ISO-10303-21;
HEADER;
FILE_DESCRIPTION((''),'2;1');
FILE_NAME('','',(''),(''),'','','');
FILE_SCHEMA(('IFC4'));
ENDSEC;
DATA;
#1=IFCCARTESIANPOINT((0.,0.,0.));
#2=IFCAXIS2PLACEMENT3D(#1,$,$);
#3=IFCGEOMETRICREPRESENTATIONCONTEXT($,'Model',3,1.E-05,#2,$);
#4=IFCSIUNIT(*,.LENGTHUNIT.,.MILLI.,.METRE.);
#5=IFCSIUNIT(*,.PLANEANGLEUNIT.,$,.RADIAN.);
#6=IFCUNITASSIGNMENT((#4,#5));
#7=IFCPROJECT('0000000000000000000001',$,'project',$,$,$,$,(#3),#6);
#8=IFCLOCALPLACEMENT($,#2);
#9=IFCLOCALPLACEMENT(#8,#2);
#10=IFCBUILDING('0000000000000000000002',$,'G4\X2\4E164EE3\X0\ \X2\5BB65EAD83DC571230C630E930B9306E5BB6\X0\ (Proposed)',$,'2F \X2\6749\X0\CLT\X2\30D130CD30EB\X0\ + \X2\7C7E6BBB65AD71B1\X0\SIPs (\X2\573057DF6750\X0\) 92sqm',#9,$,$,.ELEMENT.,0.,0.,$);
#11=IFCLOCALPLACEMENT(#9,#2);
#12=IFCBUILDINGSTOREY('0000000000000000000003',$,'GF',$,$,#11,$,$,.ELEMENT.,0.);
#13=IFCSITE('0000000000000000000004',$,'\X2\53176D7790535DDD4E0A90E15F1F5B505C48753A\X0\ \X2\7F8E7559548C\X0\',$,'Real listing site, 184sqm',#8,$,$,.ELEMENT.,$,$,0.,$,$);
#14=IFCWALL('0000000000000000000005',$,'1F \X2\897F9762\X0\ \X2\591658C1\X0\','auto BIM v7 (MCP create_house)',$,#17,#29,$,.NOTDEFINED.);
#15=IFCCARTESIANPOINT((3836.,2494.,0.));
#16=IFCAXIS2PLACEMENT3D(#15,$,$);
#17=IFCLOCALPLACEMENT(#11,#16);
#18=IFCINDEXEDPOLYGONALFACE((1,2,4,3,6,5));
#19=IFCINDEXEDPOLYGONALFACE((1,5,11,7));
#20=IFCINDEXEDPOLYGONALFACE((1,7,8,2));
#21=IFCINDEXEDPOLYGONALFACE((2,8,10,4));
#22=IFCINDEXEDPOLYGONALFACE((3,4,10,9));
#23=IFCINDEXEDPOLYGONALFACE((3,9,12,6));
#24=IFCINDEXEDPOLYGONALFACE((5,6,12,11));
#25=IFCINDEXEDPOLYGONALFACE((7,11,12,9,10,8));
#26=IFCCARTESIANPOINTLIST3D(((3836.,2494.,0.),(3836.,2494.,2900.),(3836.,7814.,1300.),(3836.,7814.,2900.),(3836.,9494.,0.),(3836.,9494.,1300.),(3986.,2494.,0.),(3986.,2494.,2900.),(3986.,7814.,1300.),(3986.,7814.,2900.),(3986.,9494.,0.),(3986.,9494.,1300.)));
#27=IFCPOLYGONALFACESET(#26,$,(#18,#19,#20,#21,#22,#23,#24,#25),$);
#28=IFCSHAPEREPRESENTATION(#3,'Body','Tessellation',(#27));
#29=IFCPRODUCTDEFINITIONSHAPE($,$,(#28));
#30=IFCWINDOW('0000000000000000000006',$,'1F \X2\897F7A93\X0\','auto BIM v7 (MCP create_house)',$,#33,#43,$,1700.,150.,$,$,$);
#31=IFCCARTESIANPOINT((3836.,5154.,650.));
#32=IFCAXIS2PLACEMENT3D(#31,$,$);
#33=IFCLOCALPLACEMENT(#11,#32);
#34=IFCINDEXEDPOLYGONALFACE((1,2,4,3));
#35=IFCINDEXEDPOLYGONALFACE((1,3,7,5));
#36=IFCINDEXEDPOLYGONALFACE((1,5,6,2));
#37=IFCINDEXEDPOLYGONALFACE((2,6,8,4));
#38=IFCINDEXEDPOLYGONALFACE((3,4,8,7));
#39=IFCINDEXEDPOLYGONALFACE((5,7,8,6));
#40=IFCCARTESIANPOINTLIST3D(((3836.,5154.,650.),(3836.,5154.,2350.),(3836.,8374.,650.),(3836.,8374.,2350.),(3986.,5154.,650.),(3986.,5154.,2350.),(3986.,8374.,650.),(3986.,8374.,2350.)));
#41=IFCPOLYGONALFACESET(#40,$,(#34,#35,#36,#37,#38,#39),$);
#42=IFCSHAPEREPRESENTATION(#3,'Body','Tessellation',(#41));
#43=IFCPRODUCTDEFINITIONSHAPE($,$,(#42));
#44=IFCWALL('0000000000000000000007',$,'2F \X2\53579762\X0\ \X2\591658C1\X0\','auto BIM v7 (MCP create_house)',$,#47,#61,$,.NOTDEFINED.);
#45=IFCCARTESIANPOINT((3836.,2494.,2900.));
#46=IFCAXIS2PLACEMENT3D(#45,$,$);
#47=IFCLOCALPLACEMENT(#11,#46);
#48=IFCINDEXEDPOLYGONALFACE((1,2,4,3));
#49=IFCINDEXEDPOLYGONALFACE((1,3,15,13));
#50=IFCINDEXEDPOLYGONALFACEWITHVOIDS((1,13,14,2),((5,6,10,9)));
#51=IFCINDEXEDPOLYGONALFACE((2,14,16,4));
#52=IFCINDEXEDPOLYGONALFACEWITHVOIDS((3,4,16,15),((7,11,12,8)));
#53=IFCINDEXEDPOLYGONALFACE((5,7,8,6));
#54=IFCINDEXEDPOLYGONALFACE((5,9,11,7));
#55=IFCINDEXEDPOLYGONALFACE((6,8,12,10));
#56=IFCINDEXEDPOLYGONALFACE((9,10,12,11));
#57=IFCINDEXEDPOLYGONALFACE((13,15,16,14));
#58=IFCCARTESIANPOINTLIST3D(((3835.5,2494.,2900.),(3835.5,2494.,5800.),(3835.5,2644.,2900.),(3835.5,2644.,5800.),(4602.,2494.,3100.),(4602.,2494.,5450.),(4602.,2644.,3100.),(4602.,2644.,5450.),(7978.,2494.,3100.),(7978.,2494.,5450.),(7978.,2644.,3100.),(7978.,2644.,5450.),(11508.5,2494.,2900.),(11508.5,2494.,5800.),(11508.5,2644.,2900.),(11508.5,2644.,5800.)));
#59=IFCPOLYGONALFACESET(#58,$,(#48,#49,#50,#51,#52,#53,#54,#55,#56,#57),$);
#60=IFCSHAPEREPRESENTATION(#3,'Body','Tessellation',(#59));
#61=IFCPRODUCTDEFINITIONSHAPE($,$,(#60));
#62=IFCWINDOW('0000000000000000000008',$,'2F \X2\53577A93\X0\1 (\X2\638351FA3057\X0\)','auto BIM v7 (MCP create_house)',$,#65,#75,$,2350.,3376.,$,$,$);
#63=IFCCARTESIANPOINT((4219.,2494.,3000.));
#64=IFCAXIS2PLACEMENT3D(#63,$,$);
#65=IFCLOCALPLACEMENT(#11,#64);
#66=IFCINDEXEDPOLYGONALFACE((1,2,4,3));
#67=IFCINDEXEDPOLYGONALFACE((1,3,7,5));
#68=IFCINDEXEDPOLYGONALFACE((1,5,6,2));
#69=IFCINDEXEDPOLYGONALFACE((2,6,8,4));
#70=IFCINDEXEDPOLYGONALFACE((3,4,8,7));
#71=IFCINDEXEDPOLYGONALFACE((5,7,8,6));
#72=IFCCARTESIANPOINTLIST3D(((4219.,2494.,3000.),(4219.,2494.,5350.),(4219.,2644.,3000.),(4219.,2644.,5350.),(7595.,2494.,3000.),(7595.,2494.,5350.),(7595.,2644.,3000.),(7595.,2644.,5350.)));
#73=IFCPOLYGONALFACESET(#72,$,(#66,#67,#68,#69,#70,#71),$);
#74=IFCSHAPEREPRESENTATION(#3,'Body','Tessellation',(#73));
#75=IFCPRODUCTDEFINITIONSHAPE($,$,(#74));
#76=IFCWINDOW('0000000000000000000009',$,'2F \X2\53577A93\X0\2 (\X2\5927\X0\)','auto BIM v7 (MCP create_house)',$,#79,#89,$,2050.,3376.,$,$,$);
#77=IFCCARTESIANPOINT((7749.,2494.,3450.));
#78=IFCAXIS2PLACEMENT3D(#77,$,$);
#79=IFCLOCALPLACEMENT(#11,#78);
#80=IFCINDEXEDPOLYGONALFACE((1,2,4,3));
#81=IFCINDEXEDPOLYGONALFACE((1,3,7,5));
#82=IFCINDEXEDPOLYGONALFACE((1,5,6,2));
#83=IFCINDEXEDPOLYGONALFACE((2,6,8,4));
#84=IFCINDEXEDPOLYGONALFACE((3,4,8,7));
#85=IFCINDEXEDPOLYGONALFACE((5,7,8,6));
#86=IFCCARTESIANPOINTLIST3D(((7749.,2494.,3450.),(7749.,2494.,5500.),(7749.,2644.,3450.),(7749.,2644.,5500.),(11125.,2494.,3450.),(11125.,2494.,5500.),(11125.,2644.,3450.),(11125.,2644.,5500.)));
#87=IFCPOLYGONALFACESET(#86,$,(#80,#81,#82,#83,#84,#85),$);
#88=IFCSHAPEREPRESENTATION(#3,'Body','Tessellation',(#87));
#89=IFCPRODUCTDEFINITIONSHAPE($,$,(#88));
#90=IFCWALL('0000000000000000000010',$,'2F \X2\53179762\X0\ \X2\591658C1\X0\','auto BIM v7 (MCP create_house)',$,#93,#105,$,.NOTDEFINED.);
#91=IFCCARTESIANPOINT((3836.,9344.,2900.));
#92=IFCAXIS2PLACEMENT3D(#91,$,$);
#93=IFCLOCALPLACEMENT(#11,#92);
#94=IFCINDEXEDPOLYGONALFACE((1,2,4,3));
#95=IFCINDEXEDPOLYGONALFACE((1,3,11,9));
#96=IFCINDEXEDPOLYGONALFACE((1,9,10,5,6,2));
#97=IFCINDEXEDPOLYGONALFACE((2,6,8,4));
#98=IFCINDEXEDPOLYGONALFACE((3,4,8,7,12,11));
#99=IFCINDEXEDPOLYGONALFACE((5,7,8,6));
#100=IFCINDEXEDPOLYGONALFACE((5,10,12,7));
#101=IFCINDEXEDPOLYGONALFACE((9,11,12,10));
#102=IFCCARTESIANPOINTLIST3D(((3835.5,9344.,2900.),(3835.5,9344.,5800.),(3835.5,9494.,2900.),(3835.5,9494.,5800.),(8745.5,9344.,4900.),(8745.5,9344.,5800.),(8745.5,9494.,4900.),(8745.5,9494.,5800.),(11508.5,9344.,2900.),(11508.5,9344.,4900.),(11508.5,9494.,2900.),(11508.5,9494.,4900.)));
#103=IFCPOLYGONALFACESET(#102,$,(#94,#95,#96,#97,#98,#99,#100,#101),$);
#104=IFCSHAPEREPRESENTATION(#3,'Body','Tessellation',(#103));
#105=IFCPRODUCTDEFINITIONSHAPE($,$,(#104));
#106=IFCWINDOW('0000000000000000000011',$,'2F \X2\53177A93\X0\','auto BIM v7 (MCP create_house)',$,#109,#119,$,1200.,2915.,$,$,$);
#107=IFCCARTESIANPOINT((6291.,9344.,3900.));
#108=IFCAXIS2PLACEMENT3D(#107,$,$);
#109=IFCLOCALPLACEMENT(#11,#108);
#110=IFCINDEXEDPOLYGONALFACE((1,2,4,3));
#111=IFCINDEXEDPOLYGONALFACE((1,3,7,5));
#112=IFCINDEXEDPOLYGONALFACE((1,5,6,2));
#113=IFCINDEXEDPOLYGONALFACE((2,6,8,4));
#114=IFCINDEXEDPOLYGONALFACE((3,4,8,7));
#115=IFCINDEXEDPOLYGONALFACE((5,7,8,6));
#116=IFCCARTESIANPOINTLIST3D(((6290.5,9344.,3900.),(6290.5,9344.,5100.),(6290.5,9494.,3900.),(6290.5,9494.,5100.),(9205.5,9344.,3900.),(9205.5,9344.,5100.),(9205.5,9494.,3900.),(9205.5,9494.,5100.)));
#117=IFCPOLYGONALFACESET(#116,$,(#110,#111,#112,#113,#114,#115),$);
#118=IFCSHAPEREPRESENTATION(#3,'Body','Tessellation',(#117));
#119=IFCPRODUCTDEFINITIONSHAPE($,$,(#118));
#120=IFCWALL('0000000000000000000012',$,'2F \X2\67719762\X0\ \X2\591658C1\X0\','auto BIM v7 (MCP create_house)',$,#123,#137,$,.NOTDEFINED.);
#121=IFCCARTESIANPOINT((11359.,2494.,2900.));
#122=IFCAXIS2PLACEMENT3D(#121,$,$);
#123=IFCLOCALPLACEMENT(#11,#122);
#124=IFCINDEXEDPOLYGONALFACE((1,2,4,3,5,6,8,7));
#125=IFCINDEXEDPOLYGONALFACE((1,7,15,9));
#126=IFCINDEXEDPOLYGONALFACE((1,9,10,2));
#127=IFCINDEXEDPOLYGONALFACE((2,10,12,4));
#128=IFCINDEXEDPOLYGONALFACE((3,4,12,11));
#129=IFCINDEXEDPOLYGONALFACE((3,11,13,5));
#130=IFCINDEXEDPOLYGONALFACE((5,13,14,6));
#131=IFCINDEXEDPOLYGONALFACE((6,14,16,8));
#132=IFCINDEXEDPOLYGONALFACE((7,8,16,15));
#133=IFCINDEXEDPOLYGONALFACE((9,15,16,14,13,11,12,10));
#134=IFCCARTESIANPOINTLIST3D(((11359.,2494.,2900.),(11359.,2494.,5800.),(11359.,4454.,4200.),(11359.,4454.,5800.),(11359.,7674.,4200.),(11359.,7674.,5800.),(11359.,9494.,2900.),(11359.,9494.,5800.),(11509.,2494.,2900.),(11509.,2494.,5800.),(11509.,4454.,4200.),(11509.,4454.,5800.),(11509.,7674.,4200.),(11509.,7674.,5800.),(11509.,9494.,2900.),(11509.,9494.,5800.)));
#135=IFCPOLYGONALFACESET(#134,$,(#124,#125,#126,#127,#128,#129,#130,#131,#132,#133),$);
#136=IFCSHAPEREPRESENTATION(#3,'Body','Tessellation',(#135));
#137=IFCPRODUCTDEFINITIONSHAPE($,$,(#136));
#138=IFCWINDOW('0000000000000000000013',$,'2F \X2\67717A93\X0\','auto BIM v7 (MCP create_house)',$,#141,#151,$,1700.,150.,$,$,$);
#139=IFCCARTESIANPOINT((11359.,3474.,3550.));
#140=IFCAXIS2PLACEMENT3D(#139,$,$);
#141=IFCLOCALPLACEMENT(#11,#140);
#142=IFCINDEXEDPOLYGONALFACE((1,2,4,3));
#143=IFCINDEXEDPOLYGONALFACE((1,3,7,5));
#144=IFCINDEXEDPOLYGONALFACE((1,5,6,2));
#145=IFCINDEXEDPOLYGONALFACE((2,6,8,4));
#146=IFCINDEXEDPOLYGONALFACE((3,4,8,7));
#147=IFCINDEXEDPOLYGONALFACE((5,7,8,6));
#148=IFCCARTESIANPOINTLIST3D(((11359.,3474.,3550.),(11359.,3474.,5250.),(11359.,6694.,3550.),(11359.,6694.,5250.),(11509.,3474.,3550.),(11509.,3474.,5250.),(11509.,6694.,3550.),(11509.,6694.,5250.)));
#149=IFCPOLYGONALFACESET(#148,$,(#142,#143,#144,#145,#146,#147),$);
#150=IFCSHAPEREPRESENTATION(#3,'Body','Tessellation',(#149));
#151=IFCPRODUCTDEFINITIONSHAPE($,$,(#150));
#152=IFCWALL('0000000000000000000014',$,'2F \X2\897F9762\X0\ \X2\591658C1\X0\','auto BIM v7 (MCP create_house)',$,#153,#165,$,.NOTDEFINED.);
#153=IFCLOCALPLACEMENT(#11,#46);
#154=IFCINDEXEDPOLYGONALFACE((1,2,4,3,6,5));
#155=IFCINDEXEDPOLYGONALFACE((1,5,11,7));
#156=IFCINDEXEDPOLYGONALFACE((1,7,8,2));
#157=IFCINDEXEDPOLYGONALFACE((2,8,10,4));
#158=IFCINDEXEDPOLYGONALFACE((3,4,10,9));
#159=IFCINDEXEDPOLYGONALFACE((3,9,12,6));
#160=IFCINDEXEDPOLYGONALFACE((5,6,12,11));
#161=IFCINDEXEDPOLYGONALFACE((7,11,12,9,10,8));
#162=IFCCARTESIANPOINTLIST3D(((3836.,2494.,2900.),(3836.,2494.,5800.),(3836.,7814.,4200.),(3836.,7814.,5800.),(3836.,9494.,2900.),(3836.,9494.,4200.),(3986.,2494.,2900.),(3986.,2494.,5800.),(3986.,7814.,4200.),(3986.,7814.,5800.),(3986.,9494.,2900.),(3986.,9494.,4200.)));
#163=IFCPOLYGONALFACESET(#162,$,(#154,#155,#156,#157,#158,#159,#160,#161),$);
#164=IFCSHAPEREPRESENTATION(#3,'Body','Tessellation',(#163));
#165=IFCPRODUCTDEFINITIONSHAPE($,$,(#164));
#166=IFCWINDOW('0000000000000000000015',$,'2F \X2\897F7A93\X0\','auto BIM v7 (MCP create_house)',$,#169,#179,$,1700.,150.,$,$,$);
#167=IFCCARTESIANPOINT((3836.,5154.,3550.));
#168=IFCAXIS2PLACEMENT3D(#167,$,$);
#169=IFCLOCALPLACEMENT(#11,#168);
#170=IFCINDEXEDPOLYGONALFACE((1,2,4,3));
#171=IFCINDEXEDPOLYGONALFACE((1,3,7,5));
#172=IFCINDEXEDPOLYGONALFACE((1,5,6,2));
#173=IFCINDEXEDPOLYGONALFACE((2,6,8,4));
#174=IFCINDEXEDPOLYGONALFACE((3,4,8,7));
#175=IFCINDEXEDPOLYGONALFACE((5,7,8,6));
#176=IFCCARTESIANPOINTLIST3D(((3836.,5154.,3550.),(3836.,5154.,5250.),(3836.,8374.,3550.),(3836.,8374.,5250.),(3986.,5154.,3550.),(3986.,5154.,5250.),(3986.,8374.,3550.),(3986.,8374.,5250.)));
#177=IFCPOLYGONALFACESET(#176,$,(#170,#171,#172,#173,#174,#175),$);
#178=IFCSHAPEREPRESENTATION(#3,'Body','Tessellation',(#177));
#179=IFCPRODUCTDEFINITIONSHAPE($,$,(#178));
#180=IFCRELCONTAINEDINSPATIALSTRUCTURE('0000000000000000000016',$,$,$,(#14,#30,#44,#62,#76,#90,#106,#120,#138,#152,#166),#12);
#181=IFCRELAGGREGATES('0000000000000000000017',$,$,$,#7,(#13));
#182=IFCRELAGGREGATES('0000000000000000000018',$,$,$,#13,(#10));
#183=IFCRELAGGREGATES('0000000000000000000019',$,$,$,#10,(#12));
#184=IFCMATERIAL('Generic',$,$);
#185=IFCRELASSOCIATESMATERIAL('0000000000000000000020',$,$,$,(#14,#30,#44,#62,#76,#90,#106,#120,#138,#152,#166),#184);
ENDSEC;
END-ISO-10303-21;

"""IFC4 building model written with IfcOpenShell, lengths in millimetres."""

from ifc_helpers import new_model, si_unit, frame, frame_2d, origin, place, context, project, spatial, rectangle, extrude, material, element, fill, save


model = new_model("IFC4")

# Units and contexts
model_context = context("Model", 3, precision=1e-05, world=origin())
ifc_project = project(units=[si_unit("LENGTHUNIT", "METRE", prefix="MILLI"), si_unit("PLANEANGLEUNIT", "RADIAN")], contexts=[model_context])

# Site, building, storey
site_placement = place(None, origin())
site = spatial("IfcSite", under=ifc_project, at=site_placement, Name="北海道川上郡弟子屈町 美留和", ObjectType="Real listing site, 184sqm", CompositionType="ELEMENT", RefElevation=0.0)
building_placement = place(site_placement, origin())
building = spatial("IfcBuilding", under=site, at=building_placement, Name="G4世代 家庭菜園テラスの家 (Proposed)", ObjectType="2F 杉CLTパネル + 籾殻断熱SIPs (地域材) 92sqm", CompositionType="ELEMENT", ElevationOfRefHeight=0.0, ElevationOfTerrain=0.0)
storey_placement = place(building_placement, origin())
storey = spatial("IfcBuildingStorey", under=building, at=storey_placement, Name="GF", CompositionType="ELEMENT", Elevation=0.0)

# Shared definitions
ifc_material = material(Name="Generic")

# Wall, opening, window
wall_1_placement = place(storey_placement, frame((3836.0, 2494.0, 0.0)))
wall_1 = element("IfcWall", 1, at=wall_1_placement, inside=storey, material=ifc_material, Name="1F 西面 外壁", Description="auto BIM v7 (MCP create_house)", PredefinedType="NOTDEFINED", context=model_context, shape_type="SweptSolid", body=[
    extrude(rectangle(XDim=150.0, YDim=7000.0, at=frame_2d((75.0, 3500.0))), frame((3836.0, 2494.0, 0.0)), (0.0, 0.0, 1.0), 2900.0),
])
opening_1_placement = place(storey_placement, frame((3836.0, 5154.0, 650.0)))
opening_1 = element("IfcOpeningElement", 2, at=opening_1_placement, cuts=wall_1, PredefinedType="NOTDEFINED", context=model_context, shape_type="SweptSolid", body=[
    extrude(rectangle(XDim=150.0, YDim=3220.0, at=frame_2d((75.0, 1610.0))), frame((3836.0, 5154.0, 650.0)), (0.0, 0.0, 1.0), 1700.0),
])
window_1_placement = place(storey_placement, frame((3836.0, 5154.0, 650.0)))
window_1 = element("IfcWindow", 3, at=window_1_placement, inside=storey, material=ifc_material, Name="1F 西窓", Description="auto BIM v7 (MCP create_house)", OverallHeight=1700.0, OverallWidth=150.0, context=model_context, shape_type="SweptSolid", body=[
    extrude(rectangle(XDim=150.0, YDim=3220.0, at=frame_2d((75.0, 1610.0))), frame((3836.0, 5154.0, 650.0)), (0.0, 0.0, 1.0), 1700.0),
])
fill(opening_1, window_1)

# Wall, openings, windows
wall_2_placement = place(storey_placement, frame((3836.0, 2494.0, 2900.0)))
wall_2 = element("IfcWall", 4, at=wall_2_placement, inside=storey, material=ifc_material, Name="2F 南面 外壁", Description="auto BIM v7 (MCP create_house)", PredefinedType="NOTDEFINED", context=model_context, shape_type="SweptSolid", body=[
    extrude(rectangle(XDim=7673.0, YDim=150.0, at=frame_2d((3836.0, 75.0))), frame((3836.0, 2494.0, 2900.0)), (0.0, 0.0, 1.0), 2900.0),
])
opening_2_placement = place(storey_placement, frame((4219.0, 2494.0, 3000.0)))
opening_2 = element("IfcOpeningElement", 5, at=opening_2_placement, cuts=wall_2, PredefinedType="NOTDEFINED", context=model_context, shape_type="SweptSolid", body=[
    extrude(rectangle(XDim=3376.0, YDim=150.0, at=frame_2d((1688.0, 75.0))), frame((4219.0, 2494.0, 3000.0)), (0.0, 0.0, 1.0), 2350.0),
])
opening_3_placement = place(storey_placement, frame((7749.0, 2494.0, 3450.0)))
opening_3 = element("IfcOpeningElement", 6, at=opening_3_placement, cuts=wall_2, PredefinedType="NOTDEFINED", context=model_context, shape_type="SweptSolid", body=[
    extrude(rectangle(XDim=3376.0, YDim=150.0, at=frame_2d((1688.0, 75.0))), frame((7749.0, 2494.0, 3450.0)), (0.0, 0.0, 1.0), 2050.0),
])
window_2_placement = place(storey_placement, frame((4219.0, 2494.0, 3000.0)))
window_2 = element("IfcWindow", 7, at=window_2_placement, inside=storey, material=ifc_material, Name="2F 南窓1 (掃出し)", Description="auto BIM v7 (MCP create_house)", OverallHeight=2350.0, OverallWidth=3376.0, context=model_context, shape_type="SweptSolid", body=[
    extrude(rectangle(XDim=3376.0, YDim=150.0, at=frame_2d((1688.0, 75.0))), frame((4219.0, 2494.0, 3000.0)), (0.0, 0.0, 1.0), 2350.0),
])
fill(opening_2, window_2)
window_3_placement = place(storey_placement, frame((7749.0, 2494.0, 3450.0)))
window_3 = element("IfcWindow", 8, at=window_3_placement, inside=storey, material=ifc_material, Name="2F 南窓2 (大)", Description="auto BIM v7 (MCP create_house)", OverallHeight=2050.0, OverallWidth=3376.0, context=model_context, shape_type="SweptSolid", body=[
    extrude(rectangle(XDim=3376.0, YDim=150.0, at=frame_2d((1688.0, 75.0))), frame((7749.0, 2494.0, 3450.0)), (0.0, 0.0, 1.0), 2050.0),
])
fill(opening_3, window_3)

# Walls, openings, windows
wall_3_placement = place(storey_placement, frame((3836.0, 9344.0, 2900.0)))
wall_3 = element("IfcWall", 9, at=wall_3_placement, inside=storey, material=ifc_material, Name="2F 北面 外壁", Description="auto BIM v7 (MCP create_house)", PredefinedType="NOTDEFINED", context=model_context, shape_type="SweptSolid", body=[
    extrude(rectangle(XDim=7673.0, YDim=150.0, at=frame_2d((3836.0, 75.0))), frame((3836.0, 9344.0, 2900.0)), (0.0, 0.0, 1.0), 2900.0),
])
opening_4_placement = place(storey_placement, frame((6291.0, 9344.0, 3900.0)))
opening_4 = element("IfcOpeningElement", 10, at=opening_4_placement, cuts=wall_3, PredefinedType="NOTDEFINED", context=model_context, shape_type="SweptSolid", body=[
    extrude(rectangle(XDim=2915.0, YDim=150.0, at=frame_2d((1457.0, 75.0))), frame((6291.0, 9344.0, 3900.0)), (0.0, 0.0, 1.0), 1200.0),
])
window_4_placement = place(storey_placement, frame((6291.0, 9344.0, 3900.0)))
window_4 = element("IfcWindow", 11, at=window_4_placement, inside=storey, material=ifc_material, Name="2F 北窓", Description="auto BIM v7 (MCP create_house)", OverallHeight=1200.0, OverallWidth=2915.0, context=model_context, shape_type="SweptSolid", body=[
    extrude(rectangle(XDim=2915.0, YDim=150.0, at=frame_2d((1457.0, 75.0))), frame((6291.0, 9344.0, 3900.0)), (0.0, 0.0, 1.0), 1200.0),
])
fill(opening_4, window_4)
wall_4_placement = place(storey_placement, frame((11359.0, 2494.0, 2900.0)))
wall_4 = element("IfcWall", 12, at=wall_4_placement, inside=storey, material=ifc_material, Name="2F 東面 外壁", Description="auto BIM v7 (MCP create_house)", PredefinedType="NOTDEFINED", context=model_context, shape_type="SweptSolid", body=[
    extrude(rectangle(XDim=150.0, YDim=7000.0, at=frame_2d((75.0, 3500.0))), frame((11359.0, 2494.0, 2900.0)), (0.0, 0.0, 1.0), 2900.0),
])
opening_5_placement = place(storey_placement, frame((11359.0, 3474.0, 3550.0)))
opening_5 = element("IfcOpeningElement", 13, at=opening_5_placement, cuts=wall_4, PredefinedType="NOTDEFINED", context=model_context, shape_type="SweptSolid", body=[
    extrude(rectangle(XDim=150.0, YDim=3220.0, at=frame_2d((75.0, 1610.0))), frame((11359.0, 3474.0, 3550.0)), (0.0, 0.0, 1.0), 1700.0),
])
window_5_placement = place(storey_placement, frame((11359.0, 3474.0, 3550.0)))
window_5 = element("IfcWindow", 14, at=window_5_placement, inside=storey, material=ifc_material, Name="2F 東窓", Description="auto BIM v7 (MCP create_house)", OverallHeight=1700.0, OverallWidth=150.0, context=model_context, shape_type="SweptSolid", body=[
    extrude(rectangle(XDim=150.0, YDim=3220.0, at=frame_2d((75.0, 1610.0))), frame((11359.0, 3474.0, 3550.0)), (0.0, 0.0, 1.0), 1700.0),
])
fill(opening_5, window_5)
wall_5_placement = place(storey_placement, frame((3836.0, 2494.0, 2900.0)))
wall_5 = element("IfcWall", 15, at=wall_5_placement, inside=storey, material=ifc_material, Name="2F 西面 外壁", Description="auto BIM v7 (MCP create_house)", PredefinedType="NOTDEFINED", context=model_context, shape_type="SweptSolid", body=[
    extrude(rectangle(XDim=150.0, YDim=7000.0, at=frame_2d((75.0, 3500.0))), frame((3836.0, 2494.0, 2900.0)), (0.0, 0.0, 1.0), 2900.0),
])
opening_6_placement = place(storey_placement, frame((3836.0, 5154.0, 3550.0)))
opening_6 = element("IfcOpeningElement", 16, at=opening_6_placement, cuts=wall_5, PredefinedType="NOTDEFINED", context=model_context, shape_type="SweptSolid", body=[
    extrude(rectangle(XDim=150.0, YDim=3220.0, at=frame_2d((75.0, 1610.0))), frame((3836.0, 5154.0, 3550.0)), (0.0, 0.0, 1.0), 1700.0),
])
window_6_placement = place(storey_placement, frame((3836.0, 5154.0, 3550.0)))
window_6 = element("IfcWindow", 17, at=window_6_placement, inside=storey, material=ifc_material, Name="2F 西窓", Description="auto BIM v7 (MCP create_house)", OverallHeight=1700.0, OverallWidth=150.0, context=model_context, shape_type="SweptSolid", body=[
    extrude(rectangle(XDim=150.0, YDim=3220.0, at=frame_2d((75.0, 1610.0))), frame((3836.0, 5154.0, 3550.0)), (0.0, 0.0, 1.0), 1700.0),
])
fill(opening_6, window_6)

save(model, "model.ifc")
